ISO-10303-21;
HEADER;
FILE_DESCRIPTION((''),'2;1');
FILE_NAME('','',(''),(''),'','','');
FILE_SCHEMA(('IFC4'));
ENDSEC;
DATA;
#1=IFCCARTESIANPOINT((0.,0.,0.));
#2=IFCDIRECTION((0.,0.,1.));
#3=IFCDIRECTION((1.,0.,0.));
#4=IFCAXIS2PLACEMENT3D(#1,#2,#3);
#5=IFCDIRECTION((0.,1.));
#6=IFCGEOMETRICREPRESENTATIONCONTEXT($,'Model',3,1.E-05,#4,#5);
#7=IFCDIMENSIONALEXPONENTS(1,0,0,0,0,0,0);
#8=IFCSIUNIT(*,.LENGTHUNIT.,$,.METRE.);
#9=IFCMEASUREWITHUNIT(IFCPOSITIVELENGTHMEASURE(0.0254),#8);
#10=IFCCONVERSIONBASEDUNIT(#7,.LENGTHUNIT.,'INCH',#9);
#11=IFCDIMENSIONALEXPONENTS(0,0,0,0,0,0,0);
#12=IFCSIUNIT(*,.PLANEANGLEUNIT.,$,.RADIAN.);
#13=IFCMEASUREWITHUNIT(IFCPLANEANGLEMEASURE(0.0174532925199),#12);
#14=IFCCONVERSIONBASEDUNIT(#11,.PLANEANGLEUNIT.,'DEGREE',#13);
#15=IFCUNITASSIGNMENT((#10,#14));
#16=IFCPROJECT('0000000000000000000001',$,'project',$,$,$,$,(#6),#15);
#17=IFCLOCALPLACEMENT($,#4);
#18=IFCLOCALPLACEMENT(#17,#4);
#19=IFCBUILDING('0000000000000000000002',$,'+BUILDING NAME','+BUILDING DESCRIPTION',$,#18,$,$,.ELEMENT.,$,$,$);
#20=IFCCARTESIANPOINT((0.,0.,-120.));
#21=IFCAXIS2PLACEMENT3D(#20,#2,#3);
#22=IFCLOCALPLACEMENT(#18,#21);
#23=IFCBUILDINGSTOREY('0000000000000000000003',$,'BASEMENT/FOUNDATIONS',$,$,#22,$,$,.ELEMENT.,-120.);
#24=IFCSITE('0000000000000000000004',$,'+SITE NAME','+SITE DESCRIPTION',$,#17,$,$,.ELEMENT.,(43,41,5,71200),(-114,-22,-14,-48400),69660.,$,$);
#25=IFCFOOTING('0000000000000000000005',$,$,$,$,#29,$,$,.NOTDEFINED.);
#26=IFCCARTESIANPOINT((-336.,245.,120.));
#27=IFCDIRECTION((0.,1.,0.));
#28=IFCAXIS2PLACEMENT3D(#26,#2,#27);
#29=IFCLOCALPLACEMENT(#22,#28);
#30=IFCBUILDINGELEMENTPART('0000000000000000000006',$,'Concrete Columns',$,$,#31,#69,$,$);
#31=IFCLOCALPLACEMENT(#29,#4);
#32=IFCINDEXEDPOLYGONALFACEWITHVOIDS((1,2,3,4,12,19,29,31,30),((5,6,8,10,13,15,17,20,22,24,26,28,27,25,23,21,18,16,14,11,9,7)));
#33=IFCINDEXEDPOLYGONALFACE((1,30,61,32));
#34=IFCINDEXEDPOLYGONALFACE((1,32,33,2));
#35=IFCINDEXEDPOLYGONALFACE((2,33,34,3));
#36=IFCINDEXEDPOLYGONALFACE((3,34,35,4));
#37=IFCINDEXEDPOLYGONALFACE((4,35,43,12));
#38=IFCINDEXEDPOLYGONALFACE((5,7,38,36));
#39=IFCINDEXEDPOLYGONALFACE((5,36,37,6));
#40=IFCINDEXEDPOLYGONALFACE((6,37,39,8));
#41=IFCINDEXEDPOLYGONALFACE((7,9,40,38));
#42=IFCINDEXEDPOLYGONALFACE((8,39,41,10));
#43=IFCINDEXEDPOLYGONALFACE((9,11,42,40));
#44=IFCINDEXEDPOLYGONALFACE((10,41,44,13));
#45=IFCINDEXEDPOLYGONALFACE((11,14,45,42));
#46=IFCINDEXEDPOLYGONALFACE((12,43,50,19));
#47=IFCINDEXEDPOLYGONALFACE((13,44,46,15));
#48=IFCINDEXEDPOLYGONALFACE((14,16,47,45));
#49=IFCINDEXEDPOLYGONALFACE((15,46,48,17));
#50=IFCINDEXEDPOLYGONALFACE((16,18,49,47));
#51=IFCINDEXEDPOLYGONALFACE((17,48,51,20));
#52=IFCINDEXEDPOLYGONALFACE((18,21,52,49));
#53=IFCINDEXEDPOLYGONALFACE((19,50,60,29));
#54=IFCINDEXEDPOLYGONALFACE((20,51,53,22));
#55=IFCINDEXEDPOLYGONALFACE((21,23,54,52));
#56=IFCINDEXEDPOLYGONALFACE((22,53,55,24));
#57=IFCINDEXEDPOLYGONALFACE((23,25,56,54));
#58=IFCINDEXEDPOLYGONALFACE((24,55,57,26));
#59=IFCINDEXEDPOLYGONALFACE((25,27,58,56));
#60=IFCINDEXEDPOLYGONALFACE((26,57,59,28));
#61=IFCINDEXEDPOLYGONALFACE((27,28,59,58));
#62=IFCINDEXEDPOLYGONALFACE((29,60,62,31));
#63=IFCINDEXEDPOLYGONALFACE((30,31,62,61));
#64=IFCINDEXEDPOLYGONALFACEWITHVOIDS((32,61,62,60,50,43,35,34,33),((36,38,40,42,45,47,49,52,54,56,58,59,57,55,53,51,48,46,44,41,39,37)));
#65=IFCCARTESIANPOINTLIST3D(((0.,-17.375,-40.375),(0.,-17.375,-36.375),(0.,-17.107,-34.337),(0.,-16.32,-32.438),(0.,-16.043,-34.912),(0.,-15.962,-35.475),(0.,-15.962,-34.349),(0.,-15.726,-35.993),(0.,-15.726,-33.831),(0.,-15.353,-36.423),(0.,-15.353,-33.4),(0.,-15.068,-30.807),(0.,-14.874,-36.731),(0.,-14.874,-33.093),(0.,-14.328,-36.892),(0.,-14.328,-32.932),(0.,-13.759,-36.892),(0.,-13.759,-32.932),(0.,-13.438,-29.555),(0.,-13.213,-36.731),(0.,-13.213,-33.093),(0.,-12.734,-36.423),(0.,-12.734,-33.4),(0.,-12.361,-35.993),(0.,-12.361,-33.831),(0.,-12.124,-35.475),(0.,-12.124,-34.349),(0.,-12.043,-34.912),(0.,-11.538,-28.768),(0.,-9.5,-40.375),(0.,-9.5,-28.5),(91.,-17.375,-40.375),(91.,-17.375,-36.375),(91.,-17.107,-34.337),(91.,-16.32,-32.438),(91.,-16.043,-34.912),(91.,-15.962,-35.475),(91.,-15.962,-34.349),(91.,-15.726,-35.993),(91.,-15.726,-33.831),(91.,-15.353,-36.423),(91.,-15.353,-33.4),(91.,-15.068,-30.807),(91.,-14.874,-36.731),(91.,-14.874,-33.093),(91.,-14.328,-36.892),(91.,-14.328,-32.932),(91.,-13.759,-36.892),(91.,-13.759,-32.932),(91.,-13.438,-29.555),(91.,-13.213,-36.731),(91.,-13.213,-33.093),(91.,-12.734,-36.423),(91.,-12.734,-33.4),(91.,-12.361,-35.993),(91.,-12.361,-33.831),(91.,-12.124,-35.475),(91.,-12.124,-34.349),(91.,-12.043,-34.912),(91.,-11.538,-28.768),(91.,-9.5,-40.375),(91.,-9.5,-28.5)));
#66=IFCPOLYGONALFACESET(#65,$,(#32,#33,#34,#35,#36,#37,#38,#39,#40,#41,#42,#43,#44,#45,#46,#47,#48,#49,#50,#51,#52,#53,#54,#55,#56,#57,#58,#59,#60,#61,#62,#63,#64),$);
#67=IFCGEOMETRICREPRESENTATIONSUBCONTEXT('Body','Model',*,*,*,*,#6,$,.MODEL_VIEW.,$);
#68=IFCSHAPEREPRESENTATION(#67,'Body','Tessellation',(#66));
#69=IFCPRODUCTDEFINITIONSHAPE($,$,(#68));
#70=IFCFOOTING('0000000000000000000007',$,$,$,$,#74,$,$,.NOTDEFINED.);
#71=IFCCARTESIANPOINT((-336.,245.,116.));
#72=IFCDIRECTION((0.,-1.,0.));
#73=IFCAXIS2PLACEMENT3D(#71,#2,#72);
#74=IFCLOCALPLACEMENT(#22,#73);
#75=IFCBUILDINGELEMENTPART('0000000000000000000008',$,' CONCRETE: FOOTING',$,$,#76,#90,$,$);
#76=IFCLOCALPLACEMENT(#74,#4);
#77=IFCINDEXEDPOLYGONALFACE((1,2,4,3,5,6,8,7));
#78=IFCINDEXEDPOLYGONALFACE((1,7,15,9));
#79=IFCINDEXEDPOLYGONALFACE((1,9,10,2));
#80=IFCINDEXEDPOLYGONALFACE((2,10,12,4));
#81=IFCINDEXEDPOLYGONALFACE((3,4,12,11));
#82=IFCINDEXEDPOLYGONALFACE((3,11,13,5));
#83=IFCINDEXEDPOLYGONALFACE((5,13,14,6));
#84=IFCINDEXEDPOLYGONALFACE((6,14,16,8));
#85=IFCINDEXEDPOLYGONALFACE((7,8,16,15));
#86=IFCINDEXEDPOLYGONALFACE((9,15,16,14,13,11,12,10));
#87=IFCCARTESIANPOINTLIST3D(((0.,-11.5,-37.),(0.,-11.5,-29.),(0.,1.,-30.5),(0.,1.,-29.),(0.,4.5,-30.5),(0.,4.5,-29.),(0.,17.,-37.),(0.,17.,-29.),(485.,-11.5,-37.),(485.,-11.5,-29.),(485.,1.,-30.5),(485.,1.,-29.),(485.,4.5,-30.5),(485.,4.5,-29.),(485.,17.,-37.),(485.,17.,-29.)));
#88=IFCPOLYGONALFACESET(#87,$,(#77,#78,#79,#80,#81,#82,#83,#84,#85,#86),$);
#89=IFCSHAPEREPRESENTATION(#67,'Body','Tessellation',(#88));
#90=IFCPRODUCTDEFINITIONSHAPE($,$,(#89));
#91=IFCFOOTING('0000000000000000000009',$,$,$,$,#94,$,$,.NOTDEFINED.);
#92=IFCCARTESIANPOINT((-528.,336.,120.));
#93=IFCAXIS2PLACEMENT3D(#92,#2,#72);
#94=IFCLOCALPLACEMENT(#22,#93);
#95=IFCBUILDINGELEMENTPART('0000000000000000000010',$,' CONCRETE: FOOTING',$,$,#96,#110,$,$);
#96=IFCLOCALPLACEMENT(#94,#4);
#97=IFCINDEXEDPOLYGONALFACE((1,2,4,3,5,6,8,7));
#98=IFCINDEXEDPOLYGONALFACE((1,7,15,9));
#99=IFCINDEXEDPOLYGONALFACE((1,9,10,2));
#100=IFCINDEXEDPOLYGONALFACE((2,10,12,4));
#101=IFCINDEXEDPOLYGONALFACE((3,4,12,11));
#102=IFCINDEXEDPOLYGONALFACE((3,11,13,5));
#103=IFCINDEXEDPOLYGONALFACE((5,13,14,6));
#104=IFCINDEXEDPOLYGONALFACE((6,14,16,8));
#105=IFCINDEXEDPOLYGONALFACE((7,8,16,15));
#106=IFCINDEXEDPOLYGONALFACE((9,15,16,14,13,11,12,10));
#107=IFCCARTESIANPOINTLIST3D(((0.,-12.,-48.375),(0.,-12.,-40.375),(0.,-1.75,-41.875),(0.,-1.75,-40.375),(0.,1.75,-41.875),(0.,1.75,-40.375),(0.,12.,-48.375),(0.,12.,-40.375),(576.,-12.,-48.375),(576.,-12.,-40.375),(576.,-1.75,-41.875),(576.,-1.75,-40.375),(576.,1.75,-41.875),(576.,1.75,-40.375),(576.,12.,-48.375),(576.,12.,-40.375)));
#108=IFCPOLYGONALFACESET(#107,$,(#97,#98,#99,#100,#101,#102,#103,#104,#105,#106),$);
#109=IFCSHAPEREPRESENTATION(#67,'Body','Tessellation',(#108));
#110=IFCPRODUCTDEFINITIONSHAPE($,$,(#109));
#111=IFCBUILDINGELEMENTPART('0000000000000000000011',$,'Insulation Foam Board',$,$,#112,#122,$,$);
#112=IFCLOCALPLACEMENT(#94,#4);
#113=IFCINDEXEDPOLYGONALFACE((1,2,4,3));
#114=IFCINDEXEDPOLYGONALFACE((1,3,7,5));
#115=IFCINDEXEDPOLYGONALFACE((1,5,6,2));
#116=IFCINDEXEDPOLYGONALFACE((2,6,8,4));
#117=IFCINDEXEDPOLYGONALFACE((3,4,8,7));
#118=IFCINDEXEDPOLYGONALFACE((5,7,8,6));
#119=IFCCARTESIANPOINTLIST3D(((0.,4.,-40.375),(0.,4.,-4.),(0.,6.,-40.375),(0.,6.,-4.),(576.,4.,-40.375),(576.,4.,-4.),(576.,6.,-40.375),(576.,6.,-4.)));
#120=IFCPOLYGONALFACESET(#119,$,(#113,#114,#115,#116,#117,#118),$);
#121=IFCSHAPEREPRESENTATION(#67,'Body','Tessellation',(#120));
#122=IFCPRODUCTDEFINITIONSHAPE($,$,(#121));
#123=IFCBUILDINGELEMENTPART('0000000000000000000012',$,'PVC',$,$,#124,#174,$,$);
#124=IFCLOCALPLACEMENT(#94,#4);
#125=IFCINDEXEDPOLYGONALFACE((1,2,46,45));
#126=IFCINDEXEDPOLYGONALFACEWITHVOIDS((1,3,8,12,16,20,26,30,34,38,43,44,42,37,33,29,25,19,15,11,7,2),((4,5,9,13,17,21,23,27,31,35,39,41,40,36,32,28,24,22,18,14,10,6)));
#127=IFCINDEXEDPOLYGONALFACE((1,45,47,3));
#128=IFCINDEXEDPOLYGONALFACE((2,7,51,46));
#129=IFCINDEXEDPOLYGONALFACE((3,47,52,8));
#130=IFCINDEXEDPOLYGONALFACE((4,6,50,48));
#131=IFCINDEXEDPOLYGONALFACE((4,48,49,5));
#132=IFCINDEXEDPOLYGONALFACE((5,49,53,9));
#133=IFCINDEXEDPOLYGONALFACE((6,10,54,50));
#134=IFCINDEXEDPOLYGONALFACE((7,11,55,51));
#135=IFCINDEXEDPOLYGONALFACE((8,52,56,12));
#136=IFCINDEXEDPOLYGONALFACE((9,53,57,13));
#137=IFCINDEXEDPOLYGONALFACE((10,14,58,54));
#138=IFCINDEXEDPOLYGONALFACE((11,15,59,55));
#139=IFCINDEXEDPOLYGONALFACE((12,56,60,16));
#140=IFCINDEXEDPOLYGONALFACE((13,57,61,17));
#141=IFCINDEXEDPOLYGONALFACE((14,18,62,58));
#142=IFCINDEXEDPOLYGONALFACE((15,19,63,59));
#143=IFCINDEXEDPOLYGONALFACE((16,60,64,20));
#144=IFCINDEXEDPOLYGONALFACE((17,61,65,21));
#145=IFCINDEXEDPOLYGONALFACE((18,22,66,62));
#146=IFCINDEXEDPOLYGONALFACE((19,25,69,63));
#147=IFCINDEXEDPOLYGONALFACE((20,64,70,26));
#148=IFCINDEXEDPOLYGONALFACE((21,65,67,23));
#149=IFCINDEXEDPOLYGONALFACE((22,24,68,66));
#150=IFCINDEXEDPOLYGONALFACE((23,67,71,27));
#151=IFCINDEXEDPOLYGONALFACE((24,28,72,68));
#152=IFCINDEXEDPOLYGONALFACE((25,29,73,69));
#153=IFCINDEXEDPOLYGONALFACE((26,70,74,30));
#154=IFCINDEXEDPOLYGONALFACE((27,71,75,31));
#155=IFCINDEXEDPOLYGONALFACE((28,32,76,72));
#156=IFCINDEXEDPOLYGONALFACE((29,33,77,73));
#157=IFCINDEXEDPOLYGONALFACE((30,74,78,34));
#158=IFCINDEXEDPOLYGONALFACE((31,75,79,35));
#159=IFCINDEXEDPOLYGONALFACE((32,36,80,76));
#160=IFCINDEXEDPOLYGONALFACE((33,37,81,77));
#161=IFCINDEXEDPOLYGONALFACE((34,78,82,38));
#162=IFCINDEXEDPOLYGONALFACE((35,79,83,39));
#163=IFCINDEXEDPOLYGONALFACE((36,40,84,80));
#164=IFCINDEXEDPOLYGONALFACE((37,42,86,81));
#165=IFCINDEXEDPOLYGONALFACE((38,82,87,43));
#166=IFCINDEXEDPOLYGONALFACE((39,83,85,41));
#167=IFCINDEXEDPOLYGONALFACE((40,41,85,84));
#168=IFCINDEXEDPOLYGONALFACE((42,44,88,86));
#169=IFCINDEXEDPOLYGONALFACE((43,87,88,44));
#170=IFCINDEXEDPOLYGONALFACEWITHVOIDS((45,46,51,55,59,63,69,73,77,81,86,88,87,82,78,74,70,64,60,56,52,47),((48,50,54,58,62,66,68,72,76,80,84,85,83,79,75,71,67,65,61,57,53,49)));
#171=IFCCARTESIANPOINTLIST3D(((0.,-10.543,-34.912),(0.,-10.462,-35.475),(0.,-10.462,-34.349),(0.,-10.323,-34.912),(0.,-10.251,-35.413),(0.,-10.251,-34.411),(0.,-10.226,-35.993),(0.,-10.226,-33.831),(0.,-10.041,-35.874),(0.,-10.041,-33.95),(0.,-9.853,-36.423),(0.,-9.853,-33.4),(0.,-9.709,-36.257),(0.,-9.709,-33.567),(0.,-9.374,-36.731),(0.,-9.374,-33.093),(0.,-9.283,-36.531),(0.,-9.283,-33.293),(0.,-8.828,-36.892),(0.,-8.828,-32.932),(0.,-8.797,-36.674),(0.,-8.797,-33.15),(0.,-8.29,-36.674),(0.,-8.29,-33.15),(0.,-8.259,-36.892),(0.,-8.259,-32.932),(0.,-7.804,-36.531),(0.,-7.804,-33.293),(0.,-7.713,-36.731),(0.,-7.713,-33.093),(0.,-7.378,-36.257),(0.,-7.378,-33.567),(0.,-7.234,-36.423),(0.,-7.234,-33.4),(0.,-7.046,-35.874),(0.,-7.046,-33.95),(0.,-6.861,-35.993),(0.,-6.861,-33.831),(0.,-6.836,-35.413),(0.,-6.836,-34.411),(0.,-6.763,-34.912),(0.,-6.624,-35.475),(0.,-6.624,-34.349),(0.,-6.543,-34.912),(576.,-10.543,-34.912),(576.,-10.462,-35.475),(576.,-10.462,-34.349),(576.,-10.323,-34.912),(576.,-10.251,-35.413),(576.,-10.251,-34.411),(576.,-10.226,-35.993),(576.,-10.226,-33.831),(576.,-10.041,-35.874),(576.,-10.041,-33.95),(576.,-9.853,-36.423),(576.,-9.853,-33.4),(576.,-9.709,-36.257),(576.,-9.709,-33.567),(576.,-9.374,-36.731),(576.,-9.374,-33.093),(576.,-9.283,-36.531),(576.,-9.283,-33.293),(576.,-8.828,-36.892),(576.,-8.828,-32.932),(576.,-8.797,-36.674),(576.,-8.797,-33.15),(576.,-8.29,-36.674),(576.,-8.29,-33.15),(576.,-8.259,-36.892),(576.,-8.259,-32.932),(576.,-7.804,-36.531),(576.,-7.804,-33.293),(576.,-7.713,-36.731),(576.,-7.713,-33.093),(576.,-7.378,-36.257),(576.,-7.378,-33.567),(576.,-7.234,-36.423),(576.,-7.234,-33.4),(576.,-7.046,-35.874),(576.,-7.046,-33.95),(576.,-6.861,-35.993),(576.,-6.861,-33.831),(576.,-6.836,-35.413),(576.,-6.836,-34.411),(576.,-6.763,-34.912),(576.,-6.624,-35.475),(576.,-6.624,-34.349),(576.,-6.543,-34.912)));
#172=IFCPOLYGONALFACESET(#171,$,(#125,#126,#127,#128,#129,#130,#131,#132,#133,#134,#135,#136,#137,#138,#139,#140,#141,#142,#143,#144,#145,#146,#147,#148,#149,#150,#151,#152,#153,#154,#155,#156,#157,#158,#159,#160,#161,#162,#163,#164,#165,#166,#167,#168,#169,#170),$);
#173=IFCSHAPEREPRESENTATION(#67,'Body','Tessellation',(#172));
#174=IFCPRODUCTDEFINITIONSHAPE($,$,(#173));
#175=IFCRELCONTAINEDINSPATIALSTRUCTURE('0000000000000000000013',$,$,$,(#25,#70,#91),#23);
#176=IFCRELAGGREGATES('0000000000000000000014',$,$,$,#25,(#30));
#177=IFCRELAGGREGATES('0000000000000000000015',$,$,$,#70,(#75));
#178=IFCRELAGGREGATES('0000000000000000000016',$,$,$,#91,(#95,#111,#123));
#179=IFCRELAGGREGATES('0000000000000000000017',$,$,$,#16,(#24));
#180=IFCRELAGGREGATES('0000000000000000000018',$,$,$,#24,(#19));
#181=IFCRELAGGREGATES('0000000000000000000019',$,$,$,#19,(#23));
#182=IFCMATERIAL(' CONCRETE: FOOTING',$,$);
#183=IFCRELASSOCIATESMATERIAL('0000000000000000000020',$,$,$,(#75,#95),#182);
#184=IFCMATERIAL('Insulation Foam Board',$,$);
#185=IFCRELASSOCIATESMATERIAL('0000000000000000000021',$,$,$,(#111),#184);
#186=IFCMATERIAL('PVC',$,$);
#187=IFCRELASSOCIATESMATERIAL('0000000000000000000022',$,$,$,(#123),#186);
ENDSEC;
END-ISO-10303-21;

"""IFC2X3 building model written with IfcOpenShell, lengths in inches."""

from ifc_helpers import new_model, entity, si_unit, converted_unit, point, direction, frame, frame_2d, origin_with_axes, place, context, subcontext, project, spatial, polyline, circle_curve, parameter, trimmed, segment, composite_curve, outline, extrude, material, element, aggregate, save


model = new_model("IFC2X3")

# Units and contexts
model_context = context("Model", 3, precision=1e-05, world=origin_with_axes(), true_north=direction((0.0, 1.0)))
body_context = subcontext(model_context, "Body", "Model", "MODEL_VIEW")
ifc_project = project(units=[converted_unit("LENGTHUNIT", "INCH", entity("IfcPositiveLengthMeasure", 0.0254), si_unit("LENGTHUNIT", "METRE"), dimensions=[1, 0, 0, 0, 0, 0, 0]), converted_unit("PLANEANGLEUNIT", "DEGREE", entity("IfcPlaneAngleMeasure", 0.0174532925199), si_unit("PLANEANGLEUNIT", "RADIAN"), dimensions=[0, 0, 0, 0, 0, 0, 0])], contexts=[model_context])

# Site, building, storey
site_placement = place(None, origin_with_axes())
site = spatial("IfcSite", under=ifc_project, at=site_placement, Name="+SITE NAME", Description="+SITE DESCRIPTION", CompositionType="ELEMENT", RefLatitude=(43, 41, 5, 71200), RefLongitude=(-114, -22, -14, -48400), RefElevation=69660.0)
building_placement = place(site_placement, origin_with_axes())
building = spatial("IfcBuilding", under=site, at=building_placement, Name="+BUILDING NAME", Description="+BUILDING DESCRIPTION", CompositionType="ELEMENT")
storey_placement = place(building_placement, frame((0.0, 0.0, -120.0), z_axis=(0.0, 0.0, 1.0), x_axis=(1.0, 0.0, 0.0)))
storey = spatial("IfcBuildingStorey", under=building, at=storey_placement, Name="BASEMENT/FOUNDATIONS", CompositionType="ELEMENT", Elevation=-120.0)

# Footings, building element parts
ifc_material_1 = material(Name=" CONCRETE: FOOTING")
footing_1_placement = place(storey_placement, frame((-336.0, 245.0, 120.0), z_axis=(0.0, 0.0, 1.0), x_axis=(0.0, 1.0, 0.0)))
footing_1 = element("IfcFooting", 1, at=footing_1_placement, inside=storey, PredefinedType="NOTDEFINED")
ifc_material_2 = material(Name="Insulation Foam Board")
ifc_material_3 = material(Name="PVC")
building_element_part_1_placement = place(footing_1_placement, origin_with_axes())
building_element_part_1 = element("IfcBuildingElementPart", 2, at=building_element_part_1_placement, Name="Concrete Columns", context=body_context, shape_type="SweptSolid", body=[
    extrude(outline(composite_curve([segment(trimmed(circle_curve(frame_2d((9.5, -36.375), x_axis=(1.0, 0.0)), 7.875), [point((17.375, -36.375)), parameter(0.0)], [point((9.5, -28.5)), parameter(90.0)], True, "CARTESIAN"), True, "CONTINUOUS"), segment(polyline([(9.5, -28.5), (9.5, -40.375), (17.375, -40.375), (17.375, -36.375)]), True, "CONTINUOUS")], self_intersect=False), holes=[composite_curve([segment(trimmed(circle_curve(frame_2d((14.043, -34.912), x_axis=(-1.0, 0.0)), 2.0), [point((16.043, -34.912)), parameter(180.0)], [point((12.043, -34.912)), parameter(0.0)], False, "CARTESIAN"), True, "CONTINUOUS"), segment(trimmed(circle_curve(frame_2d((14.043, -34.912), x_axis=(1.0, 0.0)), 2.0), [point((12.043, -34.912)), parameter(180.0)], [point((16.043, -34.912)), parameter(0.0)], False, "CARTESIAN"), True, "CONTINUOUS")], self_intersect=False)]), frame((0.0, 0.0, 0.0), z_axis=(-1.0, 0.0, 0.0), x_axis=(0.0, -1.0, 0.0)), (0.0, 0.0, -1.0), 91.0),
])
aggregate(footing_1, [building_element_part_1])
footing_2_placement = place(storey_placement, frame((-336.0, 245.0, 116.0), z_axis=(0.0, 0.0, 1.0), x_axis=(0.0, -1.0, 0.0)))
footing_2 = element("IfcFooting", 3, at=footing_2_placement, inside=storey, PredefinedType="NOTDEFINED")
building_element_part_2_placement = place(footing_2_placement, origin_with_axes())
building_element_part_2 = element("IfcBuildingElementPart", 4, at=building_element_part_2_placement, material=ifc_material_1, Name=" CONCRETE: FOOTING", context=body_context, shape_type="SweptSolid", body=[
    extrude(outline(polyline([(-14.25, -37.0), (14.25, -37.0), (14.25, -29.0), (1.75, -29.0), (1.75, -30.5), (-1.75, -30.5), (-1.75, -29.0), (-14.25, -29.0), (-14.25, -37.0)])), frame((0.0, 2.75, 0.0), z_axis=(1.0, 0.0, 0.0), x_axis=(0.0, 1.0, 0.0)), (0.0, 0.0, 1.0), 485.0),
])
aggregate(footing_2, [building_element_part_2])
footing_3_placement = place(storey_placement, frame((-528.0, 336.0, 120.0), z_axis=(0.0, 0.0, 1.0), x_axis=(0.0, -1.0, 0.0)))
footing_3 = element("IfcFooting", 5, at=footing_3_placement, inside=storey, PredefinedType="NOTDEFINED")
building_element_part_3_placement = place(footing_3_placement, origin_with_axes())
building_element_part_3 = element("IfcBuildingElementPart", 6, at=building_element_part_3_placement, material=ifc_material_1, Name=" CONCRETE: FOOTING", context=body_context, shape_type="SweptSolid", body=[
    extrude(outline(polyline([(-12.0, -48.375), (12.0, -48.375), (12.0, -40.375), (1.75, -40.375), (1.75, -41.875), (-1.75, -41.875), (-1.75, -40.375), (-12.0, -40.375), (-12.0, -48.375)])), frame((0.0, 0.0, 0.0), z_axis=(-1.0, 0.0, 0.0), x_axis=(0.0, -1.0, 0.0)), (0.0, 0.0, -1.0), 576.0),
])
building_element_part_4_placement = place(footing_3_placement, origin_with_axes())
building_element_part_4 = element("IfcBuildingElementPart", 7, at=building_element_part_4_placement, material=ifc_material_2, Name="Insulation Foam Board", context=body_context, shape_type="SweptSolid", body=[
    extrude(outline(polyline([(-4.0, -4.0), (-6.0, -4.0), (-6.0, -40.375), (-4.0, -40.375), (-4.0, -4.0)])), frame((0.0, 0.0, 0.0), z_axis=(-1.0, 0.0, 0.0), x_axis=(0.0, -1.0, 0.0)), (0.0, 0.0, -1.0), 576.0),
])
building_element_part_5_placement = place(footing_3_placement, origin_with_axes())
building_element_part_5 = element("IfcBuildingElementPart", 8, at=building_element_part_5_placement, material=ifc_material_3, Name="PVC", context=body_context, shape_type="SweptSolid", body=[
    extrude(outline(composite_curve([segment(trimmed(circle_curve(frame_2d((8.543, -34.912), x_axis=(1.0, 0.0)), 2.0), [point((10.543, -34.912)), parameter(0.0)], [point((6.543, -34.912)), parameter(180.0)], True, "CARTESIAN"), True, "CONTINUOUS"), segment(trimmed(circle_curve(frame_2d((8.543, -34.912), x_axis=(-1.0, 0.0)), 2.0), [point((6.543, -34.912)), parameter(0.0)], [point((10.543, -34.912)), parameter(180.0)], True, "CARTESIAN"), True, "CONTINUOUS")], self_intersect=False), holes=[composite_curve([segment(trimmed(circle_curve(frame_2d((8.543, -34.912), x_axis=(-1.0, 0.0)), 1.78), [point((10.323, -34.912)), parameter(180.0)], [point((6.763, -34.912)), parameter(0.0)], False, "CARTESIAN"), True, "CONTINUOUS"), segment(trimmed(circle_curve(frame_2d((8.543, -34.912), x_axis=(1.0, 0.0)), 1.78), [point((6.763, -34.912)), parameter(180.0)], [point((10.323, -34.912)), parameter(0.0)], False, "CARTESIAN"), True, "CONTINUOUS")], self_intersect=False)]), frame((0.0, 0.0, 0.0), z_axis=(-1.0, 0.0, 0.0), x_axis=(0.0, -1.0, 0.0)), (0.0, 0.0, -1.0), 576.0),
])
aggregate(footing_3, [building_element_part_3, building_element_part_4, building_element_part_5])

save(model, "model.ifc")
